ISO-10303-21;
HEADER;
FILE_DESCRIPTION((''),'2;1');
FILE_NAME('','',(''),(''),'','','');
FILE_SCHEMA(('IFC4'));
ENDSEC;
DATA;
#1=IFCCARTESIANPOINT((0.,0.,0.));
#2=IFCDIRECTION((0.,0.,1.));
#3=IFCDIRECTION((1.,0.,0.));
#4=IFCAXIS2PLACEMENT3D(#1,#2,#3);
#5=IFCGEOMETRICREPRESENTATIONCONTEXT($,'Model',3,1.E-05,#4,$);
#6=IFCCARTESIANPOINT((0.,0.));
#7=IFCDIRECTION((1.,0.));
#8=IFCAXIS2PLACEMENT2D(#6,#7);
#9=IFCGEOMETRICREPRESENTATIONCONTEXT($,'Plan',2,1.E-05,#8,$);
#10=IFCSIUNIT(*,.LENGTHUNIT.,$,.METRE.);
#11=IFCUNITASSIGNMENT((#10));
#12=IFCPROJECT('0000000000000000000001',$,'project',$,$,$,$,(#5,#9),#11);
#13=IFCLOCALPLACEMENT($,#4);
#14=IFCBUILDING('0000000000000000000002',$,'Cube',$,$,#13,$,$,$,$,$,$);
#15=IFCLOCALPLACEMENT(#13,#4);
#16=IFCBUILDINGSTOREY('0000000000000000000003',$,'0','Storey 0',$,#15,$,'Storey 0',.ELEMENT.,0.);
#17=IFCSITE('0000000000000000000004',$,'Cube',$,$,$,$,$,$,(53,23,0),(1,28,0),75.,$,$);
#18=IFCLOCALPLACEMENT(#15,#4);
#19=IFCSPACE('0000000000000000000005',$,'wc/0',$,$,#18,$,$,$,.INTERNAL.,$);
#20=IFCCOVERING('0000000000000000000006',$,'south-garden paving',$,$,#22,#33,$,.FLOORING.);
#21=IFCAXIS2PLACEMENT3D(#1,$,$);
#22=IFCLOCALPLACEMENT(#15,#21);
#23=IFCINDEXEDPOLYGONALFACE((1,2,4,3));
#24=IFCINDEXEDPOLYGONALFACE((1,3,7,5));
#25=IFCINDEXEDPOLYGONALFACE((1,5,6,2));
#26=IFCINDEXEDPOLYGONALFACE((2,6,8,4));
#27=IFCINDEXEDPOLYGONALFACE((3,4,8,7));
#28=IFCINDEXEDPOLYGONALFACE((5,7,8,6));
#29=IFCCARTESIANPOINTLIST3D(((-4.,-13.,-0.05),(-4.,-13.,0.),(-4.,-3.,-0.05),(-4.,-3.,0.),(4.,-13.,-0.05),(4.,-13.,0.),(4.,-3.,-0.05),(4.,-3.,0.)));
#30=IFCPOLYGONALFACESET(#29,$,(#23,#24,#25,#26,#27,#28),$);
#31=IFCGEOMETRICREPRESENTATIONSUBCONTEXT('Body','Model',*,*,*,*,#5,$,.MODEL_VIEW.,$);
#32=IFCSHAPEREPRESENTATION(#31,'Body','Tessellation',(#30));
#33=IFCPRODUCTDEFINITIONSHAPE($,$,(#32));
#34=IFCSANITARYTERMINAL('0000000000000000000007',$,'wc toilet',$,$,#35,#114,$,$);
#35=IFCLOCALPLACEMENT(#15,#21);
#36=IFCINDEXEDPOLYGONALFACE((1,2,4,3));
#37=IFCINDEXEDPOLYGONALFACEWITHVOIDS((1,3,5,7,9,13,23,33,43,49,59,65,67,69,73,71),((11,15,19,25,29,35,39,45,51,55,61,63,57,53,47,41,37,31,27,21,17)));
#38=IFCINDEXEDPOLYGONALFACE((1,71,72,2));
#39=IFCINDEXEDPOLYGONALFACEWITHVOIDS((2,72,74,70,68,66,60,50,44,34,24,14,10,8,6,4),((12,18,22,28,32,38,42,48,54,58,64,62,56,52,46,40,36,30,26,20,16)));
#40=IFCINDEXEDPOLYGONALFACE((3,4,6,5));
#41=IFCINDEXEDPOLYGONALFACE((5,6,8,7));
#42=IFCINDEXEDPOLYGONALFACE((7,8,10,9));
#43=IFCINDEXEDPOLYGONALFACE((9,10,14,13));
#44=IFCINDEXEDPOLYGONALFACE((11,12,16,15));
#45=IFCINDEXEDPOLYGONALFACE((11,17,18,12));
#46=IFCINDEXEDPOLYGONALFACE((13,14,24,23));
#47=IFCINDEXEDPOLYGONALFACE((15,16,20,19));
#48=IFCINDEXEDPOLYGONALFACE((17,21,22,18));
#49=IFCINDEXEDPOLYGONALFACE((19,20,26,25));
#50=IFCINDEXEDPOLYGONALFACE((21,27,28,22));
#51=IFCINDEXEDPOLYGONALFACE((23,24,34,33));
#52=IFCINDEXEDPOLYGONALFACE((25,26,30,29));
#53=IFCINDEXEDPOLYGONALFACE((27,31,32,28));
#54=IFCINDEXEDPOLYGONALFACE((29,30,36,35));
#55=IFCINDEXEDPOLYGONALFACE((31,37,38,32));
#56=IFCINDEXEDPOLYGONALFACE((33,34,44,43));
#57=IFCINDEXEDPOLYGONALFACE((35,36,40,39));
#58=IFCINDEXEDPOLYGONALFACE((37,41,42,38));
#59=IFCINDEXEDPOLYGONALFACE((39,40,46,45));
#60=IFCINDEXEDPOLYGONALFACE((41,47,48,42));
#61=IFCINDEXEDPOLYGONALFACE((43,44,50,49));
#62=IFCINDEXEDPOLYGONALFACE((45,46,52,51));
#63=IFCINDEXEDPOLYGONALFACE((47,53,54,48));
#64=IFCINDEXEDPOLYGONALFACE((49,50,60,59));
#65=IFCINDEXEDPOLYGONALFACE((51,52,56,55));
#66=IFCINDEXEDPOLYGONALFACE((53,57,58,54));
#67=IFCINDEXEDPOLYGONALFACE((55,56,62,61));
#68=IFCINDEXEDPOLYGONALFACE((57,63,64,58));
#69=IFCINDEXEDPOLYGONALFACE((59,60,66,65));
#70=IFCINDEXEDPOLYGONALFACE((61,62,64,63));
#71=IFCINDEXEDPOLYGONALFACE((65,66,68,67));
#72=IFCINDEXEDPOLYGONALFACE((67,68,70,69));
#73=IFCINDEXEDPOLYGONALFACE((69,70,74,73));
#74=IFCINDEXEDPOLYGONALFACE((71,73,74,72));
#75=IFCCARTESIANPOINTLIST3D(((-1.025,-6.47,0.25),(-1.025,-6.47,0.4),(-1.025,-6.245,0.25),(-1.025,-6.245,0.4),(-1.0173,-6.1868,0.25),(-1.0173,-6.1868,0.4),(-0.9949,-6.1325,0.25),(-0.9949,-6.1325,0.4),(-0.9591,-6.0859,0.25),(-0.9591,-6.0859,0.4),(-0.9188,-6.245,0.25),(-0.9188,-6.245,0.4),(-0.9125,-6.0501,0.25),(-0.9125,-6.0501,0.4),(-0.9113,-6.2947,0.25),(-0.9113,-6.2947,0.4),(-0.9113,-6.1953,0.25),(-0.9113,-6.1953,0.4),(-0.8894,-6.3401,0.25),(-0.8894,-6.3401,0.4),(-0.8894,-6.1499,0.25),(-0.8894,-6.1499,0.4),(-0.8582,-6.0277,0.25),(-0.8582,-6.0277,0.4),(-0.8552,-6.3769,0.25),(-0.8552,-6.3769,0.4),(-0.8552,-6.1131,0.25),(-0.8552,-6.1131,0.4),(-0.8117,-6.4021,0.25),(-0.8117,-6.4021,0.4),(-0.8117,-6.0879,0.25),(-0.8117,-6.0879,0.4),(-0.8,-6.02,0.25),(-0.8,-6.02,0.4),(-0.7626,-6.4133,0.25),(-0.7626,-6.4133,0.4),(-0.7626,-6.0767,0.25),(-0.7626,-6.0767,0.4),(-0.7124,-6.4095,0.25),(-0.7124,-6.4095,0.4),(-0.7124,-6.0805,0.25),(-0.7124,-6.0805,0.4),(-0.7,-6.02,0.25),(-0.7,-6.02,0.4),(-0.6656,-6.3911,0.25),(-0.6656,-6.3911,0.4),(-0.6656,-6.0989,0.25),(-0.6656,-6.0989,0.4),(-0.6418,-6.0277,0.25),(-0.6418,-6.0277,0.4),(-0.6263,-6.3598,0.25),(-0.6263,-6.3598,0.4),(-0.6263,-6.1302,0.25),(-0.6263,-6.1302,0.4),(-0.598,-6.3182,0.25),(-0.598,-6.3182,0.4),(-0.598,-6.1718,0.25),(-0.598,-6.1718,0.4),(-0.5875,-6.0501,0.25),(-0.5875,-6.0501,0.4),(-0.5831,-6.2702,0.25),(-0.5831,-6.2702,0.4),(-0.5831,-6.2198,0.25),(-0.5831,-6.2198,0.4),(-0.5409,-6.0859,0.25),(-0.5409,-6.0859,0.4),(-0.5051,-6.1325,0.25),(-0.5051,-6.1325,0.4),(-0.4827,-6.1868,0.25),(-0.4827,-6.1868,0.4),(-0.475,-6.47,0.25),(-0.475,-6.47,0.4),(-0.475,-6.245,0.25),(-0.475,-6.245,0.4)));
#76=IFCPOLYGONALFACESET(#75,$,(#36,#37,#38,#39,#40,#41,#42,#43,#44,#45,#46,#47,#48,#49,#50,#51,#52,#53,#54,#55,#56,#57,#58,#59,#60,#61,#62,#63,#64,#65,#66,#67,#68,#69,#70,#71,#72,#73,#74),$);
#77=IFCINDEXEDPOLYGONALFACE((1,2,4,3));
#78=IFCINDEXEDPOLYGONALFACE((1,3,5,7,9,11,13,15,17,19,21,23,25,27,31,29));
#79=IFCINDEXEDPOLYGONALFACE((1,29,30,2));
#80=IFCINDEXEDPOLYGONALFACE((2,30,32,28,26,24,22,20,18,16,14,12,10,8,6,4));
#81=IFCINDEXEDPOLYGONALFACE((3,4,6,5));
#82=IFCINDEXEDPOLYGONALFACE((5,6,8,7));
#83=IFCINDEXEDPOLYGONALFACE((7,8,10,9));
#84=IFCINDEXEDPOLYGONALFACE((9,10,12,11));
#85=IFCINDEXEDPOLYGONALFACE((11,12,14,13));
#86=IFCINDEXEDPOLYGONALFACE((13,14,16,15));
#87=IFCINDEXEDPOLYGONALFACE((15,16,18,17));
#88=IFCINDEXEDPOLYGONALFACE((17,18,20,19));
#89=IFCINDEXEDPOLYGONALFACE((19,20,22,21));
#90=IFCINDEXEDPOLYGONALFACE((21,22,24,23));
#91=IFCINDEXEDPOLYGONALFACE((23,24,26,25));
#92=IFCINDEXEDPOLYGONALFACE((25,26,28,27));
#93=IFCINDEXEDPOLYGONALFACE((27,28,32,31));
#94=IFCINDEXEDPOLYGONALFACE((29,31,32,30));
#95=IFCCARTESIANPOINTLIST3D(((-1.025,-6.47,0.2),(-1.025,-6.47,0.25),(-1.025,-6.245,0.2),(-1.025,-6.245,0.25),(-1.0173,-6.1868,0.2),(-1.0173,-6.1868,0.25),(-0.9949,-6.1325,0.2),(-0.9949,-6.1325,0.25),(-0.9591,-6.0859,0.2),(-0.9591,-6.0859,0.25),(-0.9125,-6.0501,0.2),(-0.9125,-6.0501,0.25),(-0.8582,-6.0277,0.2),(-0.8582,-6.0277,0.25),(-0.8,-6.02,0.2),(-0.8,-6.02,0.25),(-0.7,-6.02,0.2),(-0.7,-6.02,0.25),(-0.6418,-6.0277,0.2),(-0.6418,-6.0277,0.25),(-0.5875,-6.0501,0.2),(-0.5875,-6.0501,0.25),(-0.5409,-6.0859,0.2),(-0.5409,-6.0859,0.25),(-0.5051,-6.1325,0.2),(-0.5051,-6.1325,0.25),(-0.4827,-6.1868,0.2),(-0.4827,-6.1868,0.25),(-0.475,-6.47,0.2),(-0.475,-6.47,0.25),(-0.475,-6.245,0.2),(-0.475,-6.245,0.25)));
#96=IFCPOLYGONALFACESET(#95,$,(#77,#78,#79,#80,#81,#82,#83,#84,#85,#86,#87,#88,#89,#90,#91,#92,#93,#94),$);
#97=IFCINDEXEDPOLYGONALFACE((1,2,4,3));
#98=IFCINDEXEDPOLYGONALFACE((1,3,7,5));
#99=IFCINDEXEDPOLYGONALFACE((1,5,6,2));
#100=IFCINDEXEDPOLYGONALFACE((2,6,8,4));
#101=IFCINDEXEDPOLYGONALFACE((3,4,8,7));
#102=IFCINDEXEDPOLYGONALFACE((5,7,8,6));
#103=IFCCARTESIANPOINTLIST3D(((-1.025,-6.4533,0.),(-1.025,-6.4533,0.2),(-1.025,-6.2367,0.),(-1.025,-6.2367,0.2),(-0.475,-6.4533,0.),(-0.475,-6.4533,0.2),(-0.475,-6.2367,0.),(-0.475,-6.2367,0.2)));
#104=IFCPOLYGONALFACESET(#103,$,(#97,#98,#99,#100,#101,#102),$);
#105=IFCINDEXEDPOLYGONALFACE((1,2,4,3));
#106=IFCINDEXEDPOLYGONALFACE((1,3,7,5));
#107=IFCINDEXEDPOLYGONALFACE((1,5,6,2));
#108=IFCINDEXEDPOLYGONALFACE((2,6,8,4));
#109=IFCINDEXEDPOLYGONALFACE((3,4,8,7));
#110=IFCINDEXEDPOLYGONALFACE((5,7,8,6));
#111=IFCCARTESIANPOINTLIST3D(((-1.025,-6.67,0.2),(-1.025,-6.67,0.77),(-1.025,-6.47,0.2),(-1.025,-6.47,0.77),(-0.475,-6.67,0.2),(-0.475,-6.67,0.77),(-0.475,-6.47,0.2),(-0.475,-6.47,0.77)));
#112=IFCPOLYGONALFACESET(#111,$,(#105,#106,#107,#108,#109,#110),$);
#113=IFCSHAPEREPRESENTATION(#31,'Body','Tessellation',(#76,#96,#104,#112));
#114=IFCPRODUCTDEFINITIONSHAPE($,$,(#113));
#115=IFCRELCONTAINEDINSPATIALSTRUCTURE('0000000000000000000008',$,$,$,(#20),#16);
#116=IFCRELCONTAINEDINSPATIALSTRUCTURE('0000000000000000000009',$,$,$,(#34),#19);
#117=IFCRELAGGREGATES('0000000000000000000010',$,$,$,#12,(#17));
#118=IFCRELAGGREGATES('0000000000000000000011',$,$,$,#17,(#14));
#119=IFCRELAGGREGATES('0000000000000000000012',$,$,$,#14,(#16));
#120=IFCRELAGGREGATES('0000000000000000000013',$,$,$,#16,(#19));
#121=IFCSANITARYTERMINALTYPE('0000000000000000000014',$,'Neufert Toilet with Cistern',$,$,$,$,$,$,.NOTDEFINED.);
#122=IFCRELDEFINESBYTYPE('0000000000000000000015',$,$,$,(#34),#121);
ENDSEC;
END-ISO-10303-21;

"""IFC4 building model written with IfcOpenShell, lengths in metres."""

from ifc_helpers import new_model, entity, si_unit, frame, frame_2d, origin_with_axes, origin_2d_with_axis, place, context, subcontext, project, spatial, line, arc, indexed_curve, circle_curve, outline, extrude, shape, source, transform, mapped, type_object, type_shapes, element, save


model = new_model("IFC4")

# Units and contexts
model_context = context("Model", 3, precision=1e-05, world=origin_with_axes())
plan_context = context("Plan", 2, precision=1e-05, world=origin_2d_with_axis())
body_context_1 = subcontext(model_context, "Body", "Model", "MODEL_VIEW")
body_context_2 = subcontext(plan_context, "Body", "Plan", "PLAN_VIEW")
ifc_project = project(units=[si_unit("LENGTHUNIT", "METRE")], contexts=[model_context, plan_context])

# Site, building, storey
site = spatial("IfcSite", under=ifc_project, Name="Cube", RefLatitude=(53, 23, 0), RefLongitude=(1, 28, 0), RefElevation=75.0)
building_placement = place(None, origin_with_axes())
building = spatial("IfcBuilding", under=site, at=building_placement, Name="Cube")
storey_placement = place(building_placement, origin_with_axes())
storey = spatial("IfcBuildingStorey", under=building, at=storey_placement, Name="0", Description="Storey 0", LongName="Storey 0", CompositionType="ELEMENT", Elevation=0.0)

# Covering
covering_placement = place(storey_placement, frame((-4.0, -13.0, 0.0), z_axis=(0.0, 0.0, 1.0), x_axis=(1.0, 0.0, 0.0)))
element("IfcCovering", 1, at=covering_placement, inside=storey, Name="south-garden paving", PredefinedType="FLOORING", context=body_context_1, shape_type="SweptSolid", body=[
    extrude(outline(indexed_curve([(0.0, 0.0), (8.0, 0.0), (8.0, 10.0), (0.0, 10.0)])), None, (0.0, 0.0, -1.0), 0.05),
])

# Shared definitions
space_1_placement = place(storey_placement, origin_with_axes())
space_1 = spatial("IfcSpace", under=storey, at=space_1_placement, Name="wc/0", PredefinedType="INTERNAL")

# Sanitary terminal
sanitary_terminal_type_1 = type_object("IfcSanitaryTerminalType", Name="Neufert Toilet with Cistern", PredefinedType="NOTDEFINED")
shared_shape_1 = source(origin_with_axes(), body_context_1, "Body", "SweptSolid", [
    extrude(outline(indexed_curve([(-0.275, -0.2), (0.275, -0.2), (0.275, -0.425), (0.2091, -0.5841), (0.05, -0.65), (-0.05, -0.65), (-0.2091, -0.5841), (-0.275, -0.425)], segments=[line(1, 2), line(2, 3), arc(3, 4, 5), line(5, 6), arc(6, 7, 8), line(8, 1)]), holes=[circle_curve(frame_2d((0.0, -0.425)), 0.1688)]), frame((0.0, 0.0, 0.25), z_axis=(0.0, 0.0, 1.0), x_axis=(1.0, 0.0, 0.0)), (0.0, 0.0, 1.0), 0.15),
    extrude(outline(indexed_curve([(-0.275, -0.2), (0.275, -0.2), (0.275, -0.425), (0.2091, -0.5841), (0.05, -0.65), (-0.05, -0.65), (-0.2091, -0.5841), (-0.275, -0.425)], segments=[line(1, 2), line(2, 3), arc(3, 4, 5), line(5, 6), arc(6, 7, 8), line(8, 1)])), frame((0.0, 0.0, 0.2), z_axis=(0.0, 0.0, 1.0), x_axis=(1.0, 0.0, 0.0)), (0.0, 0.0, 1.0), 0.05),
    extrude(outline(indexed_curve([(-0.275, -0.2167), (0.275, -0.2167), (0.275, -0.4333), (-0.275, -0.4333)], segments=[line(1, 2, 3, 4, 1)])), origin_with_axes(), (0.0, 0.0, 1.0), 0.2),
    extrude(outline(indexed_curve([(-0.275, 0.0), (0.275, 0.0), (0.275, -0.2), (-0.275, -0.2)], segments=[line(1, 2, 3, 4, 1)])), frame((0.0, 0.0, 0.2), z_axis=(0.0, 0.0, 1.0), x_axis=(1.0, 0.0, 0.0)), (0.0, 0.0, 1.0), 0.57),
])
shared_shape_2 = source(origin_with_axes(), body_context_2, "Body", "Curve2D", [
    entity("IfcIndexedPolyCurve", entity("IfcCartesianPointList2D", [[-0.275, 0.0], [0.275, 0.0], [0.275, -0.2], [-0.275, -0.2]]), [entity("IfcLineIndex", [1, 2, 3, 4, 1])]),
    entity("IfcIndexedPolyCurve", entity("IfcCartesianPointList2D", [[0.165, -0.2], [0.1925, -0.335]])),
    entity("IfcTrimmedCurve", entity("IfcEllipse", entity("IfcAxis2Placement2D", entity("IfcCartesianPoint", [0.0, -0.335]), entity("IfcDirection", [1.0, 0.0])), 0.1925, 0.315), [entity("IfcCartesianPoint", [-0.1925, -0.335])], [entity("IfcCartesianPoint", [0.1925, -0.335])], True, "CARTESIAN"),
    entity("IfcIndexedPolyCurve", entity("IfcCartesianPointList2D", [[-0.165, -0.2], [-0.1925, -0.335]])),
    entity("IfcEllipse", entity("IfcAxis2Placement2D", entity("IfcCartesianPoint", [0.0, -0.452]), entity("IfcDirection", [1.0, 0.0])), 0.1313, 0.1575),
    entity("IfcIndexedPolyCurve", entity("IfcCartesianPointList2D", [[-0.0344, -0.452], [-0.0344, -0.4295], [0.0344, -0.4295], [0.0344, -0.452]])),
    entity("IfcTrimmedCurve", entity("IfcEllipse", entity("IfcAxis2Placement2D", entity("IfcCartesianPoint", [0.0, -0.452]), entity("IfcDirection", [1.0, 0.0])), 0.0344, 0.0225), [entity("IfcCartesianPoint", [-0.0344, -0.452])], [entity("IfcCartesianPoint", [0.0344, -0.452])], True, "CARTESIAN"),
])
type_shapes(sanitary_terminal_type_1, [shared_shape_1, shared_shape_2])
sanitary_terminal_1_placement = place(space_1_placement, frame((-0.75, -6.67, 0.0), z_axis=(0.0, 0.0, 1.0), x_axis=(-1.0, 0.0, 0.0)))
element("IfcSanitaryTerminal", 2, at=sanitary_terminal_1_placement, inside=space_1, type_object=sanitary_terminal_type_1, Name="wc toilet", shapes=[
    shape(body_context_1, "Body", "MappedRepresentation", [mapped(shared_shape_1, transform((0.0, 0.0, 0.0), x_axis=(1.0, 0.0, 0.0), y_axis=(0.0, 1.0, 0.0), z_axis=(0.0, 0.0, 1.0), scale=1.0))]),
    shape(body_context_2, "Body", "MappedRepresentation", [mapped(shared_shape_2, transform((0.0, 0.0, 0.0), x_axis=(1.0, 0.0, 0.0), y_axis=(0.0, 1.0, 0.0), z_axis=(0.0, 0.0, 1.0), scale=1.0))]),
])

save(model, "model.ifc")
